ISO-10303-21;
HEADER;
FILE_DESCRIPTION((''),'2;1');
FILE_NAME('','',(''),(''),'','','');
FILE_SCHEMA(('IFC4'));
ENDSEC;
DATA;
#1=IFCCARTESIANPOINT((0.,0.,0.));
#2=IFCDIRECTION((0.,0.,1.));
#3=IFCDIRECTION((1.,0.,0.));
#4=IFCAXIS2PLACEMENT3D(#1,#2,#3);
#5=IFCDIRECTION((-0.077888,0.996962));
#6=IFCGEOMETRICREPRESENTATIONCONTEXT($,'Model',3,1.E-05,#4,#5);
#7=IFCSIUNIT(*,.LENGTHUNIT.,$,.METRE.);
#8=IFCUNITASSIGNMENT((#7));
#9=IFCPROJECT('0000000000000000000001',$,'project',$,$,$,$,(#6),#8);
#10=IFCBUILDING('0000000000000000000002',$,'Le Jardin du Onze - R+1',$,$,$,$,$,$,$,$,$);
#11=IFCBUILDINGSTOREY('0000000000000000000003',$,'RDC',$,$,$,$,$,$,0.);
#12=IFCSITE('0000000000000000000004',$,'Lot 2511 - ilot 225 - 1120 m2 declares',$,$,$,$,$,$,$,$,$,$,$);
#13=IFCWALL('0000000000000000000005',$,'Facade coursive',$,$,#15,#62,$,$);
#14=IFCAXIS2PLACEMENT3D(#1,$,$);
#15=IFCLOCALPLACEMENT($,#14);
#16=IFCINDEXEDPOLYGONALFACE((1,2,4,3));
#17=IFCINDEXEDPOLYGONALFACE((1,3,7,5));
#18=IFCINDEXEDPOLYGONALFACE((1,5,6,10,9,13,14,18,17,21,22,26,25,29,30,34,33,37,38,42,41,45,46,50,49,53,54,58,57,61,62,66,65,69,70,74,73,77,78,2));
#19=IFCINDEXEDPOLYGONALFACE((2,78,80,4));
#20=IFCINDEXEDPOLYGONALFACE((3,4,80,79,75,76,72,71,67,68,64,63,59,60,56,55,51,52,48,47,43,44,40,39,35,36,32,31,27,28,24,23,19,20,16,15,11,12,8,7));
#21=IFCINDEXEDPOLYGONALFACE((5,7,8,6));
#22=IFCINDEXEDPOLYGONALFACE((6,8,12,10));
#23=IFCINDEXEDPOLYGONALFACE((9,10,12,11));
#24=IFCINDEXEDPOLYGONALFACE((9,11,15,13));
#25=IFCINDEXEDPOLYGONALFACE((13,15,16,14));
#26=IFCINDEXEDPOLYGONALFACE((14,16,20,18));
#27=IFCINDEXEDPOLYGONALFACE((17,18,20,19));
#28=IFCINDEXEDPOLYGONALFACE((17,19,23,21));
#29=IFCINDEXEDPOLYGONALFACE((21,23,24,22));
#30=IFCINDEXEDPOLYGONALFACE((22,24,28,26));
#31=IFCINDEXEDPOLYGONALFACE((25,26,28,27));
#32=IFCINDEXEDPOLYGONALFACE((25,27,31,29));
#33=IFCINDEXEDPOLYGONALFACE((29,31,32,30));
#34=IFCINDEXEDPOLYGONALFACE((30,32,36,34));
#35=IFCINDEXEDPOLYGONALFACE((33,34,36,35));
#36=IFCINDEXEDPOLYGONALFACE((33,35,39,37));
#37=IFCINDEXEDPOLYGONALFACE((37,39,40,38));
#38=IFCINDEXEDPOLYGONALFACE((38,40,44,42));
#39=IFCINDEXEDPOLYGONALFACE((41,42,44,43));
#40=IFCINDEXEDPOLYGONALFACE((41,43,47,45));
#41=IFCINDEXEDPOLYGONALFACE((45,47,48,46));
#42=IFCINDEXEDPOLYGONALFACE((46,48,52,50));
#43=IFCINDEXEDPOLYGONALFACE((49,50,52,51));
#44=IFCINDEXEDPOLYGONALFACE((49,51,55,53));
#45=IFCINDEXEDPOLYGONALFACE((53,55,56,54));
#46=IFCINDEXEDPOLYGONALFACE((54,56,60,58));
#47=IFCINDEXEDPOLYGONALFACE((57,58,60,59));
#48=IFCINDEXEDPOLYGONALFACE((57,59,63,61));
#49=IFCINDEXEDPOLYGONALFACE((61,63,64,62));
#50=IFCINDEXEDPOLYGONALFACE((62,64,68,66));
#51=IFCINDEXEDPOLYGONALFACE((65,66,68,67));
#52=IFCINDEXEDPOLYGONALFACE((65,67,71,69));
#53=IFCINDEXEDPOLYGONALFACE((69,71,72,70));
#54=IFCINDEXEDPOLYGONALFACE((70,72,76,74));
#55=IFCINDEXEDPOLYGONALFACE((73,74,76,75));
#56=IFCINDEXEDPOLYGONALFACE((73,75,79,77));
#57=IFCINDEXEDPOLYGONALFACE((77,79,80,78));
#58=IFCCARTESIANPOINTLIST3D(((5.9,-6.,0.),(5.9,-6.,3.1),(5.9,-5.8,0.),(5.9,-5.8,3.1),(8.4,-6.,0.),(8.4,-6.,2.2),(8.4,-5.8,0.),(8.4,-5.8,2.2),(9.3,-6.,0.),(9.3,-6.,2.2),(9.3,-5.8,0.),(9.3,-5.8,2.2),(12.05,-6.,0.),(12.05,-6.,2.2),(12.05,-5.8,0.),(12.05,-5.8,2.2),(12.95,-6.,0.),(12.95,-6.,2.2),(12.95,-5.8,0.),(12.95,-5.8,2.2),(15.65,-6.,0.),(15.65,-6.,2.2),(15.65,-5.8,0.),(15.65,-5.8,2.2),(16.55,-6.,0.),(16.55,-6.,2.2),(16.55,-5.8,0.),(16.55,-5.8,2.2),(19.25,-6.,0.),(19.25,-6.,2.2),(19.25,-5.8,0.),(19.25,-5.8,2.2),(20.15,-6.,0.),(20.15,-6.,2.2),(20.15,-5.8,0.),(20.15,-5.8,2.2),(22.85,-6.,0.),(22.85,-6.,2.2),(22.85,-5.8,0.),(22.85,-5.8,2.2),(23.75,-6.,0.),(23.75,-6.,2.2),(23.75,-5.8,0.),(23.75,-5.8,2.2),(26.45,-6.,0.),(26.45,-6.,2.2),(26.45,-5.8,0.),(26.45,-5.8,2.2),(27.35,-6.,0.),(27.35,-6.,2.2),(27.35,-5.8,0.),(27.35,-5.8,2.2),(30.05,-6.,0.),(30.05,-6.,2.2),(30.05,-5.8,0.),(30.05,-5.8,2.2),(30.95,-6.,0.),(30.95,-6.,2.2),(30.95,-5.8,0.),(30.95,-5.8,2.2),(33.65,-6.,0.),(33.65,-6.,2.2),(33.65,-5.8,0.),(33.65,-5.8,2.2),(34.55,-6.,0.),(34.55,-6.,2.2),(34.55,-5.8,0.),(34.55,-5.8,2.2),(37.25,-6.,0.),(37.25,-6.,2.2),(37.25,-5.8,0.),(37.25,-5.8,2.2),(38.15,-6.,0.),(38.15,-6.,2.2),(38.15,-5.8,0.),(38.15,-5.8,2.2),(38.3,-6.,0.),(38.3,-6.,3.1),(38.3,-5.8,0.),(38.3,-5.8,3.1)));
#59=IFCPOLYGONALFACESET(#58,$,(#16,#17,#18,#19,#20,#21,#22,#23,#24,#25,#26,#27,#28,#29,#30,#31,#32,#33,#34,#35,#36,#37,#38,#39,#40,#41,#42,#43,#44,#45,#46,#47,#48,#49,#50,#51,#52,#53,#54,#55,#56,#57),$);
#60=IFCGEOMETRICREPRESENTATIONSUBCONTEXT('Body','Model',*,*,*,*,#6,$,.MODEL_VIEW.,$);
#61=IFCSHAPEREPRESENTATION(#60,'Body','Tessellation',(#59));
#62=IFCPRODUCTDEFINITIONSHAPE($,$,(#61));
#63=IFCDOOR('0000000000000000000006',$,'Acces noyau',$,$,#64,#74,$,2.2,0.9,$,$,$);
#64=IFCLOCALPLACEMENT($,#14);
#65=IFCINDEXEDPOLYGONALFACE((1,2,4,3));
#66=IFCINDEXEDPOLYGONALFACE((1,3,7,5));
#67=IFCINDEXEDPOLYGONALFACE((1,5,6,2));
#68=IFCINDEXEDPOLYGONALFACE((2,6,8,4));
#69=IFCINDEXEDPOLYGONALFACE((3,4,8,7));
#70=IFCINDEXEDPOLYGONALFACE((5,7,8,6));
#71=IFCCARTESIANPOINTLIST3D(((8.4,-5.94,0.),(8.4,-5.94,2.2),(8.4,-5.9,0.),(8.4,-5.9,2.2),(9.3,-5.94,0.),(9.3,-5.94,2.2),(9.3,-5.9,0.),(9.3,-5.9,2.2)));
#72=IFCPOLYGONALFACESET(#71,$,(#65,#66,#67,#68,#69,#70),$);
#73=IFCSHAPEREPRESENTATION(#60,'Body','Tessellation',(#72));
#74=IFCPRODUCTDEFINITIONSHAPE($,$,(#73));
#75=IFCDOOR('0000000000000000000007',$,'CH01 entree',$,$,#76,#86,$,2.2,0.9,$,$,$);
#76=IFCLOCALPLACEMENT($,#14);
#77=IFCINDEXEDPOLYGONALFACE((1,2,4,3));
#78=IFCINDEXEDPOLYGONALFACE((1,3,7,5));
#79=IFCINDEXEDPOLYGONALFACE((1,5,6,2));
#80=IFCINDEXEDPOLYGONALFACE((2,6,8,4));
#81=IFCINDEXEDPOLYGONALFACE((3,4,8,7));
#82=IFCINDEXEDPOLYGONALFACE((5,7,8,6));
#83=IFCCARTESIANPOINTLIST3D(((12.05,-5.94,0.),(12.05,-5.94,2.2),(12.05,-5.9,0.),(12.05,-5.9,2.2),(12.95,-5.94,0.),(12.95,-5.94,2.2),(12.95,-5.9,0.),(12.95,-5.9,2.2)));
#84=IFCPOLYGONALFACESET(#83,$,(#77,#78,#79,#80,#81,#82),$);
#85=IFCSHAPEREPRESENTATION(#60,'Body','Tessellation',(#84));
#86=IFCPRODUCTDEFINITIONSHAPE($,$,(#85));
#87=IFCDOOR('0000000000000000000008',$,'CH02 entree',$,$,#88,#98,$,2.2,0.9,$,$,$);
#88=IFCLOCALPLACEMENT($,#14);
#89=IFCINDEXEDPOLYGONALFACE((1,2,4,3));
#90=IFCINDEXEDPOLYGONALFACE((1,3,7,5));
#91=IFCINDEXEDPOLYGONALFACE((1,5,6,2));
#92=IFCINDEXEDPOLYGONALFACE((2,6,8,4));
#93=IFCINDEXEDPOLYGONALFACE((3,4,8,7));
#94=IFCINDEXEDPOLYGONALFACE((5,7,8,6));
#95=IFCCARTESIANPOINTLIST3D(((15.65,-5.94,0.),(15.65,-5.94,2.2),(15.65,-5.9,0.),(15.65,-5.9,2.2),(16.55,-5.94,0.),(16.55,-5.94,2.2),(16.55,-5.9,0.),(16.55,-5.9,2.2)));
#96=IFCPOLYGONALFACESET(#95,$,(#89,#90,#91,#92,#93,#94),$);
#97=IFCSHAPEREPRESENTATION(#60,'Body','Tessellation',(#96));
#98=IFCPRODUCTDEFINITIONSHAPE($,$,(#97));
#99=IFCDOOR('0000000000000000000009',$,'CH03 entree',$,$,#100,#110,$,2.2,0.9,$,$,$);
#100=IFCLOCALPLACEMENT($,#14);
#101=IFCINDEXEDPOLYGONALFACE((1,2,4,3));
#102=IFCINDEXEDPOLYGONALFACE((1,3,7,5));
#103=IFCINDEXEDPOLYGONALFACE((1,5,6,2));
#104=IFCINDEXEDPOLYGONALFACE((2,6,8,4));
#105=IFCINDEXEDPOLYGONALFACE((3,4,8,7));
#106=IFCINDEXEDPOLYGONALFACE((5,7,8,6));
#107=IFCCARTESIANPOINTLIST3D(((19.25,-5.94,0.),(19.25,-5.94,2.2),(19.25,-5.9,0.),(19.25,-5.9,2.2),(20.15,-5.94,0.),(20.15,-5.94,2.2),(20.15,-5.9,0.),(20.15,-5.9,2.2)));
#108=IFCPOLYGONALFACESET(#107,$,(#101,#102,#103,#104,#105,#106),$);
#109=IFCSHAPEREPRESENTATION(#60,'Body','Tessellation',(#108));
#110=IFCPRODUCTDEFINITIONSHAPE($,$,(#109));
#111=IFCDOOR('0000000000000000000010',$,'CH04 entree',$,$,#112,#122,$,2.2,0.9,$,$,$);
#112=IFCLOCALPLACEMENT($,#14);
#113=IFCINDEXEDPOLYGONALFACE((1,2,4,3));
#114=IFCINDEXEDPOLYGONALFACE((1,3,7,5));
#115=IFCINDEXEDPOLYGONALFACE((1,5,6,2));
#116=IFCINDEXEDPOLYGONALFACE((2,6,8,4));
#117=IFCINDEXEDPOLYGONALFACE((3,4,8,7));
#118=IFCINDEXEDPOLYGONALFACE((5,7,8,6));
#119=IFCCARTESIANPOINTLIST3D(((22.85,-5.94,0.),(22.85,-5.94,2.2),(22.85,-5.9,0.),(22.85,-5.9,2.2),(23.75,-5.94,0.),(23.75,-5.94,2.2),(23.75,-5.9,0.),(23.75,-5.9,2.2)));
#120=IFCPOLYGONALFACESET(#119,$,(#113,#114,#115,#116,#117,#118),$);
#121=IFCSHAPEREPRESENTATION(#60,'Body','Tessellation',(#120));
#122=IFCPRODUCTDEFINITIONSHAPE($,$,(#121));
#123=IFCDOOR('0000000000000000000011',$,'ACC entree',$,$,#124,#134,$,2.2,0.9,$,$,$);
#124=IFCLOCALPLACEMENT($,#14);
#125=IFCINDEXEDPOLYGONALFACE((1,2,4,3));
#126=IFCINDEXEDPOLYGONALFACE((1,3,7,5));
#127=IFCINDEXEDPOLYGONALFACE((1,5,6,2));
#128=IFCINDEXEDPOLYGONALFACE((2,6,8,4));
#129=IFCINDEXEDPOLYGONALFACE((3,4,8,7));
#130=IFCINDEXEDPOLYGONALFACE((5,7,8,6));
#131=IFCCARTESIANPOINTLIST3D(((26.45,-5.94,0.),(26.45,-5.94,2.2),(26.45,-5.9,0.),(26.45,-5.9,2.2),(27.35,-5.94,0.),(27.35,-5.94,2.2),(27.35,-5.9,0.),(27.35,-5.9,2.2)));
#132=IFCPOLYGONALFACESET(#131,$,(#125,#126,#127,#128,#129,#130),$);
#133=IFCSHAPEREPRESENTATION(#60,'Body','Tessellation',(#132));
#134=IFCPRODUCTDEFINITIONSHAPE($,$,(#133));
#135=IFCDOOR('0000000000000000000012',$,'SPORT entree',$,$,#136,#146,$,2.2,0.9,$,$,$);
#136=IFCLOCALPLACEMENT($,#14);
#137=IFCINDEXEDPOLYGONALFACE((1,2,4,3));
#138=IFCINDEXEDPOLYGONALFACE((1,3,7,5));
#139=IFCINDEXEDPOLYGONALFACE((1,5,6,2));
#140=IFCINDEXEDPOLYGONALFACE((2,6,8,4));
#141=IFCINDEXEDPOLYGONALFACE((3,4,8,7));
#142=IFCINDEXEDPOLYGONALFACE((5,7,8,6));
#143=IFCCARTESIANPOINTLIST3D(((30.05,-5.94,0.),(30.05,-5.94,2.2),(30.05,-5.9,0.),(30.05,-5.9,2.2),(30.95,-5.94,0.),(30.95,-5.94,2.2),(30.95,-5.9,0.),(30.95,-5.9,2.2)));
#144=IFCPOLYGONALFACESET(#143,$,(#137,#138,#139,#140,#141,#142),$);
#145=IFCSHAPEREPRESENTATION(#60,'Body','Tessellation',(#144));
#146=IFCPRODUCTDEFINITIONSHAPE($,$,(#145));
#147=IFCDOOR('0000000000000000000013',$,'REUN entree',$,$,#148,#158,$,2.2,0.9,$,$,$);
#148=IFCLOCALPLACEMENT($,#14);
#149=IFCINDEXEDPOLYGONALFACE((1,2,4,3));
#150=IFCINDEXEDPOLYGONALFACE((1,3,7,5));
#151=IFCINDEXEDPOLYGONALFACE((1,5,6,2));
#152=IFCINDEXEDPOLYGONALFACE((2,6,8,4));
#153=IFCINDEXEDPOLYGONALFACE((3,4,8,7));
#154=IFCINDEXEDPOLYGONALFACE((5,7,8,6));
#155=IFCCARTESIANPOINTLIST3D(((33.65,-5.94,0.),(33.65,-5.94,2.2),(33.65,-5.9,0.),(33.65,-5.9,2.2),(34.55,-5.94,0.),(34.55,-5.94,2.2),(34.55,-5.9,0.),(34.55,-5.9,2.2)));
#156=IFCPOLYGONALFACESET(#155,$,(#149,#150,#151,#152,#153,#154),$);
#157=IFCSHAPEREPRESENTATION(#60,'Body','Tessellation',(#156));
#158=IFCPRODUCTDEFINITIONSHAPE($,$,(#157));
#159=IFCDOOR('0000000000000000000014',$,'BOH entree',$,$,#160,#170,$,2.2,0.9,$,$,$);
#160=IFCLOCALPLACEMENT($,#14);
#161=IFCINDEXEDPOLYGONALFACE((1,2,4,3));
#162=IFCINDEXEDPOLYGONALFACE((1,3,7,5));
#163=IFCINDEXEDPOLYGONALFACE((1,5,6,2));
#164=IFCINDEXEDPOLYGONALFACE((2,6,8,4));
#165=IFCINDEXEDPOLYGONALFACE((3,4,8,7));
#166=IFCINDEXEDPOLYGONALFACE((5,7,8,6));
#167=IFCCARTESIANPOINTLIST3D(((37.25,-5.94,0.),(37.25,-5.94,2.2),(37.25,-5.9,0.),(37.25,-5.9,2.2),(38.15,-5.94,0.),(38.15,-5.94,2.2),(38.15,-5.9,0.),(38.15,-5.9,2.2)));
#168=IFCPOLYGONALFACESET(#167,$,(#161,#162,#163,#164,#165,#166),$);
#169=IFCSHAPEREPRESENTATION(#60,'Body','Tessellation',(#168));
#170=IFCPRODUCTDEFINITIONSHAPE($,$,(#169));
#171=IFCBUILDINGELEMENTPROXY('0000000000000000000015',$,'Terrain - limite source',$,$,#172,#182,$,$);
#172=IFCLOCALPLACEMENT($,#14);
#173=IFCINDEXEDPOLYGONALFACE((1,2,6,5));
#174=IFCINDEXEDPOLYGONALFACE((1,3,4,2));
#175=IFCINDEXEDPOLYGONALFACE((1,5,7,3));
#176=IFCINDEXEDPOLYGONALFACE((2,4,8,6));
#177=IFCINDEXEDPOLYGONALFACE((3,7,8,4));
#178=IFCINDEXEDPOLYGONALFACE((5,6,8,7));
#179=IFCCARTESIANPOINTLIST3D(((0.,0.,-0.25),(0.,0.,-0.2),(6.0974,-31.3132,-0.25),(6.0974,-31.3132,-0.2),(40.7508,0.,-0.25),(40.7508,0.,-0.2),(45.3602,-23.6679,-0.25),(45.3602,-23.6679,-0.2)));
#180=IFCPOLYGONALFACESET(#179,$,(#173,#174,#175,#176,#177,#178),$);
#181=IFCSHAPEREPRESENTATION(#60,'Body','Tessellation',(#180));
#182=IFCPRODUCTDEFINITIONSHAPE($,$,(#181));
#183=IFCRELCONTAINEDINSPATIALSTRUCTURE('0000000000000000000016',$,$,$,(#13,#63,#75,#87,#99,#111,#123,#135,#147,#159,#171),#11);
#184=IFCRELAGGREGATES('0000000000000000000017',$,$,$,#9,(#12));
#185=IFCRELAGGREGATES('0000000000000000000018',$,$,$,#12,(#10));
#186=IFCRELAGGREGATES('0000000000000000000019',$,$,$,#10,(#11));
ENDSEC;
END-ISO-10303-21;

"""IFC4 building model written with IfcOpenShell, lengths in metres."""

from ifc_helpers import new_model, si_unit, direction, frame, origin, origin_with_axes, place, context, subcontext, project, spatial, polyline, outline, extrude, element, fill, save


model = new_model("IFC4")

# Units and contexts
model_context = context("Model", 3, precision=1e-05, world=origin_with_axes(), true_north=direction((-0.077888, 0.996962)))
body_context = subcontext(model_context, "Body", "Model", "MODEL_VIEW")
ifc_project = project(units=[si_unit("LENGTHUNIT", "METRE")], contexts=[model_context])

# Site, building, storey
site = spatial("IfcSite", under=ifc_project, Name="Lot 2511 - ilot 225 - 1120 m2 declares")
building = spatial("IfcBuilding", under=site, Name="Le Jardin du Onze - R+1")
storey = spatial("IfcBuildingStorey", under=building, Name="RDC", Elevation=0.0)

# Wall, openings, doors
wall_1_placement = place(None, origin_with_axes())
wall_1 = element("IfcWall", 1, at=wall_1_placement, inside=storey, Name="Facade coursive", context=body_context, shape_type="SweptSolid", body=[
    extrude(outline(polyline([(38.3, -6.0), (38.3, -5.8), (5.9, -5.8), (5.9, -6.0), (38.3, -6.0)])), origin(), (0.0, 0.0, 1.0), 3.1),
])
opening_1_placement = place(None, origin_with_axes())
opening_1 = element("IfcOpeningElement", 2, at=opening_1_placement, cuts=wall_1, context=body_context, shape_type="SweptSolid", body=[
    extrude(outline(polyline([(9.3, -6.04), (9.3, -5.76), (8.4, -5.76), (8.4, -6.04), (9.3, -6.04)])), origin(), (0.0, 0.0, 1.0), 2.2),
])
opening_2_placement = place(None, origin_with_axes())
opening_2 = element("IfcOpeningElement", 3, at=opening_2_placement, cuts=wall_1, context=body_context, shape_type="SweptSolid", body=[
    extrude(outline(polyline([(12.95, -6.04), (12.95, -5.76), (12.05, -5.76), (12.05, -6.04), (12.95, -6.04)])), origin(), (0.0, 0.0, 1.0), 2.2),
])
opening_3_placement = place(None, origin_with_axes())
opening_3 = element("IfcOpeningElement", 4, at=opening_3_placement, cuts=wall_1, context=body_context, shape_type="SweptSolid", body=[
    extrude(outline(polyline([(16.55, -6.04), (16.55, -5.76), (15.65, -5.76), (15.65, -6.04), (16.55, -6.04)])), origin(), (0.0, 0.0, 1.0), 2.2),
])
opening_4_placement = place(None, origin_with_axes())
opening_4 = element("IfcOpeningElement", 5, at=opening_4_placement, cuts=wall_1, context=body_context, shape_type="SweptSolid", body=[
    extrude(outline(polyline([(20.15, -6.04), (20.15, -5.76), (19.25, -5.76), (19.25, -6.04), (20.15, -6.04)])), origin(), (0.0, 0.0, 1.0), 2.2),
])
opening_5_placement = place(None, origin_with_axes())
opening_5 = element("IfcOpeningElement", 6, at=opening_5_placement, cuts=wall_1, context=body_context, shape_type="SweptSolid", body=[
    extrude(outline(polyline([(23.75, -6.04), (23.75, -5.76), (22.85, -5.76), (22.85, -6.04), (23.75, -6.04)])), origin(), (0.0, 0.0, 1.0), 2.2),
])
opening_6_placement = place(None, origin_with_axes())
opening_6 = element("IfcOpeningElement", 7, at=opening_6_placement, cuts=wall_1, context=body_context, shape_type="SweptSolid", body=[
    extrude(outline(polyline([(27.35, -6.04), (27.35, -5.76), (26.45, -5.76), (26.45, -6.04), (27.35, -6.04)])), origin(), (0.0, 0.0, 1.0), 2.2),
])
opening_7_placement = place(None, origin_with_axes())
opening_7 = element("IfcOpeningElement", 8, at=opening_7_placement, cuts=wall_1, context=body_context, shape_type="SweptSolid", body=[
    extrude(outline(polyline([(30.95, -6.04), (30.95, -5.76), (30.05, -5.76), (30.05, -6.04), (30.95, -6.04)])), origin(), (0.0, 0.0, 1.0), 2.2),
])
opening_8_placement = place(None, origin_with_axes())
opening_8 = element("IfcOpeningElement", 9, at=opening_8_placement, cuts=wall_1, context=body_context, shape_type="SweptSolid", body=[
    extrude(outline(polyline([(34.55, -6.04), (34.55, -5.76), (33.65, -5.76), (33.65, -6.04), (34.55, -6.04)])), origin(), (0.0, 0.0, 1.0), 2.2),
])
opening_9_placement = place(None, origin_with_axes())
opening_9 = element("IfcOpeningElement", 10, at=opening_9_placement, cuts=wall_1, context=body_context, shape_type="SweptSolid", body=[
    extrude(outline(polyline([(38.15, -6.04), (38.15, -5.76), (37.25, -5.76), (37.25, -6.04), (38.15, -6.04)])), origin(), (0.0, 0.0, 1.0), 2.2),
])
door_1_placement = place(None, origin_with_axes())
door_1 = element("IfcDoor", 11, at=door_1_placement, inside=storey, Name="Acces noyau", OverallHeight=2.2, OverallWidth=0.9, context=body_context, shape_type="SweptSolid", body=[
    extrude(outline(polyline([(9.3, -5.94), (9.3, -5.9), (8.4, -5.9), (8.4, -5.94), (9.3, -5.94)])), origin(), (0.0, 0.0, 1.0), 2.2),
])
fill(opening_1, door_1)
door_2_placement = place(None, origin_with_axes())
door_2 = element("IfcDoor", 12, at=door_2_placement, inside=storey, Name="CH01 entree", OverallHeight=2.2, OverallWidth=0.9, context=body_context, shape_type="SweptSolid", body=[
    extrude(outline(polyline([(12.95, -5.94), (12.95, -5.9), (12.05, -5.9), (12.05, -5.94), (12.95, -5.94)])), origin(), (0.0, 0.0, 1.0), 2.2),
])
fill(opening_2, door_2)
door_3_placement = place(None, origin_with_axes())
door_3 = element("IfcDoor", 13, at=door_3_placement, inside=storey, Name="CH02 entree", OverallHeight=2.2, OverallWidth=0.9, context=body_context, shape_type="SweptSolid", body=[
    extrude(outline(polyline([(16.55, -5.94), (16.55, -5.9), (15.65, -5.9), (15.65, -5.94), (16.55, -5.94)])), origin(), (0.0, 0.0, 1.0), 2.2),
])
fill(opening_3, door_3)
door_4_placement = place(None, origin_with_axes())
door_4 = element("IfcDoor", 14, at=door_4_placement, inside=storey, Name="CH03 entree", OverallHeight=2.2, OverallWidth=0.9, context=body_context, shape_type="SweptSolid", body=[
    extrude(outline(polyline([(20.15, -5.94), (20.15, -5.9), (19.25, -5.9), (19.25, -5.94), (20.15, -5.94)])), origin(), (0.0, 0.0, 1.0), 2.2),
])
fill(opening_4, door_4)
door_5_placement = place(None, origin_with_axes())
door_5 = element("IfcDoor", 15, at=door_5_placement, inside=storey, Name="CH04 entree", OverallHeight=2.2, OverallWidth=0.9, context=body_context, shape_type="SweptSolid", body=[
    extrude(outline(polyline([(23.75, -5.94), (23.75, -5.9), (22.85, -5.9), (22.85, -5.94), (23.75, -5.94)])), origin(), (0.0, 0.0, 1.0), 2.2),
])
fill(opening_5, door_5)
door_6_placement = place(None, origin_with_axes())
door_6 = element("IfcDoor", 16, at=door_6_placement, inside=storey, Name="ACC entree", OverallHeight=2.2, OverallWidth=0.9, context=body_context, shape_type="SweptSolid", body=[
    extrude(outline(polyline([(27.35, -5.94), (27.35, -5.9), (26.45, -5.9), (26.45, -5.94), (27.35, -5.94)])), origin(), (0.0, 0.0, 1.0), 2.2),
])
fill(opening_6, door_6)
door_7_placement = place(None, origin_with_axes())
door_7 = element("IfcDoor", 17, at=door_7_placement, inside=storey, Name="SPORT entree", OverallHeight=2.2, OverallWidth=0.9, context=body_context, shape_type="SweptSolid", body=[
    extrude(outline(polyline([(30.95, -5.94), (30.95, -5.9), (30.05, -5.9), (30.05, -5.94), (30.95, -5.94)])), origin(), (0.0, 0.0, 1.0), 2.2),
])
fill(opening_7, door_7)
door_8_placement = place(None, origin_with_axes())
door_8 = element("IfcDoor", 18, at=door_8_placement, inside=storey, Name="REUN entree", OverallHeight=2.2, OverallWidth=0.9, context=body_context, shape_type="SweptSolid", body=[
    extrude(outline(polyline([(34.55, -5.94), (34.55, -5.9), (33.65, -5.9), (33.65, -5.94), (34.55, -5.94)])), origin(), (0.0, 0.0, 1.0), 2.2),
])
fill(opening_8, door_8)
door_9_placement = place(None, origin_with_axes())
door_9 = element("IfcDoor", 19, at=door_9_placement, inside=storey, Name="BOH entree", OverallHeight=2.2, OverallWidth=0.9, context=body_context, shape_type="SweptSolid", body=[
    extrude(outline(polyline([(38.15, -5.94), (38.15, -5.9), (37.25, -5.9), (37.25, -5.94), (38.15, -5.94)])), origin(), (0.0, 0.0, 1.0), 2.2),
])
fill(opening_9, door_9)

# Building element proxy
proxy_placement = place(None, origin_with_axes())
element("IfcBuildingElementProxy", 20, at=proxy_placement, inside=storey, Name="Terrain - limite source", context=body_context, shape_type="SweptSolid", body=[
    extrude(outline(polyline([(0.0, 0.0), (6.0974, -31.3132), (45.3602, -23.6679), (40.7508, 0.0), (0.0, 0.0)])), frame((0.0, 0.0, -0.25)), (0.0, 0.0, 1.0), 0.05),
])

save(model, "model.ifc")
